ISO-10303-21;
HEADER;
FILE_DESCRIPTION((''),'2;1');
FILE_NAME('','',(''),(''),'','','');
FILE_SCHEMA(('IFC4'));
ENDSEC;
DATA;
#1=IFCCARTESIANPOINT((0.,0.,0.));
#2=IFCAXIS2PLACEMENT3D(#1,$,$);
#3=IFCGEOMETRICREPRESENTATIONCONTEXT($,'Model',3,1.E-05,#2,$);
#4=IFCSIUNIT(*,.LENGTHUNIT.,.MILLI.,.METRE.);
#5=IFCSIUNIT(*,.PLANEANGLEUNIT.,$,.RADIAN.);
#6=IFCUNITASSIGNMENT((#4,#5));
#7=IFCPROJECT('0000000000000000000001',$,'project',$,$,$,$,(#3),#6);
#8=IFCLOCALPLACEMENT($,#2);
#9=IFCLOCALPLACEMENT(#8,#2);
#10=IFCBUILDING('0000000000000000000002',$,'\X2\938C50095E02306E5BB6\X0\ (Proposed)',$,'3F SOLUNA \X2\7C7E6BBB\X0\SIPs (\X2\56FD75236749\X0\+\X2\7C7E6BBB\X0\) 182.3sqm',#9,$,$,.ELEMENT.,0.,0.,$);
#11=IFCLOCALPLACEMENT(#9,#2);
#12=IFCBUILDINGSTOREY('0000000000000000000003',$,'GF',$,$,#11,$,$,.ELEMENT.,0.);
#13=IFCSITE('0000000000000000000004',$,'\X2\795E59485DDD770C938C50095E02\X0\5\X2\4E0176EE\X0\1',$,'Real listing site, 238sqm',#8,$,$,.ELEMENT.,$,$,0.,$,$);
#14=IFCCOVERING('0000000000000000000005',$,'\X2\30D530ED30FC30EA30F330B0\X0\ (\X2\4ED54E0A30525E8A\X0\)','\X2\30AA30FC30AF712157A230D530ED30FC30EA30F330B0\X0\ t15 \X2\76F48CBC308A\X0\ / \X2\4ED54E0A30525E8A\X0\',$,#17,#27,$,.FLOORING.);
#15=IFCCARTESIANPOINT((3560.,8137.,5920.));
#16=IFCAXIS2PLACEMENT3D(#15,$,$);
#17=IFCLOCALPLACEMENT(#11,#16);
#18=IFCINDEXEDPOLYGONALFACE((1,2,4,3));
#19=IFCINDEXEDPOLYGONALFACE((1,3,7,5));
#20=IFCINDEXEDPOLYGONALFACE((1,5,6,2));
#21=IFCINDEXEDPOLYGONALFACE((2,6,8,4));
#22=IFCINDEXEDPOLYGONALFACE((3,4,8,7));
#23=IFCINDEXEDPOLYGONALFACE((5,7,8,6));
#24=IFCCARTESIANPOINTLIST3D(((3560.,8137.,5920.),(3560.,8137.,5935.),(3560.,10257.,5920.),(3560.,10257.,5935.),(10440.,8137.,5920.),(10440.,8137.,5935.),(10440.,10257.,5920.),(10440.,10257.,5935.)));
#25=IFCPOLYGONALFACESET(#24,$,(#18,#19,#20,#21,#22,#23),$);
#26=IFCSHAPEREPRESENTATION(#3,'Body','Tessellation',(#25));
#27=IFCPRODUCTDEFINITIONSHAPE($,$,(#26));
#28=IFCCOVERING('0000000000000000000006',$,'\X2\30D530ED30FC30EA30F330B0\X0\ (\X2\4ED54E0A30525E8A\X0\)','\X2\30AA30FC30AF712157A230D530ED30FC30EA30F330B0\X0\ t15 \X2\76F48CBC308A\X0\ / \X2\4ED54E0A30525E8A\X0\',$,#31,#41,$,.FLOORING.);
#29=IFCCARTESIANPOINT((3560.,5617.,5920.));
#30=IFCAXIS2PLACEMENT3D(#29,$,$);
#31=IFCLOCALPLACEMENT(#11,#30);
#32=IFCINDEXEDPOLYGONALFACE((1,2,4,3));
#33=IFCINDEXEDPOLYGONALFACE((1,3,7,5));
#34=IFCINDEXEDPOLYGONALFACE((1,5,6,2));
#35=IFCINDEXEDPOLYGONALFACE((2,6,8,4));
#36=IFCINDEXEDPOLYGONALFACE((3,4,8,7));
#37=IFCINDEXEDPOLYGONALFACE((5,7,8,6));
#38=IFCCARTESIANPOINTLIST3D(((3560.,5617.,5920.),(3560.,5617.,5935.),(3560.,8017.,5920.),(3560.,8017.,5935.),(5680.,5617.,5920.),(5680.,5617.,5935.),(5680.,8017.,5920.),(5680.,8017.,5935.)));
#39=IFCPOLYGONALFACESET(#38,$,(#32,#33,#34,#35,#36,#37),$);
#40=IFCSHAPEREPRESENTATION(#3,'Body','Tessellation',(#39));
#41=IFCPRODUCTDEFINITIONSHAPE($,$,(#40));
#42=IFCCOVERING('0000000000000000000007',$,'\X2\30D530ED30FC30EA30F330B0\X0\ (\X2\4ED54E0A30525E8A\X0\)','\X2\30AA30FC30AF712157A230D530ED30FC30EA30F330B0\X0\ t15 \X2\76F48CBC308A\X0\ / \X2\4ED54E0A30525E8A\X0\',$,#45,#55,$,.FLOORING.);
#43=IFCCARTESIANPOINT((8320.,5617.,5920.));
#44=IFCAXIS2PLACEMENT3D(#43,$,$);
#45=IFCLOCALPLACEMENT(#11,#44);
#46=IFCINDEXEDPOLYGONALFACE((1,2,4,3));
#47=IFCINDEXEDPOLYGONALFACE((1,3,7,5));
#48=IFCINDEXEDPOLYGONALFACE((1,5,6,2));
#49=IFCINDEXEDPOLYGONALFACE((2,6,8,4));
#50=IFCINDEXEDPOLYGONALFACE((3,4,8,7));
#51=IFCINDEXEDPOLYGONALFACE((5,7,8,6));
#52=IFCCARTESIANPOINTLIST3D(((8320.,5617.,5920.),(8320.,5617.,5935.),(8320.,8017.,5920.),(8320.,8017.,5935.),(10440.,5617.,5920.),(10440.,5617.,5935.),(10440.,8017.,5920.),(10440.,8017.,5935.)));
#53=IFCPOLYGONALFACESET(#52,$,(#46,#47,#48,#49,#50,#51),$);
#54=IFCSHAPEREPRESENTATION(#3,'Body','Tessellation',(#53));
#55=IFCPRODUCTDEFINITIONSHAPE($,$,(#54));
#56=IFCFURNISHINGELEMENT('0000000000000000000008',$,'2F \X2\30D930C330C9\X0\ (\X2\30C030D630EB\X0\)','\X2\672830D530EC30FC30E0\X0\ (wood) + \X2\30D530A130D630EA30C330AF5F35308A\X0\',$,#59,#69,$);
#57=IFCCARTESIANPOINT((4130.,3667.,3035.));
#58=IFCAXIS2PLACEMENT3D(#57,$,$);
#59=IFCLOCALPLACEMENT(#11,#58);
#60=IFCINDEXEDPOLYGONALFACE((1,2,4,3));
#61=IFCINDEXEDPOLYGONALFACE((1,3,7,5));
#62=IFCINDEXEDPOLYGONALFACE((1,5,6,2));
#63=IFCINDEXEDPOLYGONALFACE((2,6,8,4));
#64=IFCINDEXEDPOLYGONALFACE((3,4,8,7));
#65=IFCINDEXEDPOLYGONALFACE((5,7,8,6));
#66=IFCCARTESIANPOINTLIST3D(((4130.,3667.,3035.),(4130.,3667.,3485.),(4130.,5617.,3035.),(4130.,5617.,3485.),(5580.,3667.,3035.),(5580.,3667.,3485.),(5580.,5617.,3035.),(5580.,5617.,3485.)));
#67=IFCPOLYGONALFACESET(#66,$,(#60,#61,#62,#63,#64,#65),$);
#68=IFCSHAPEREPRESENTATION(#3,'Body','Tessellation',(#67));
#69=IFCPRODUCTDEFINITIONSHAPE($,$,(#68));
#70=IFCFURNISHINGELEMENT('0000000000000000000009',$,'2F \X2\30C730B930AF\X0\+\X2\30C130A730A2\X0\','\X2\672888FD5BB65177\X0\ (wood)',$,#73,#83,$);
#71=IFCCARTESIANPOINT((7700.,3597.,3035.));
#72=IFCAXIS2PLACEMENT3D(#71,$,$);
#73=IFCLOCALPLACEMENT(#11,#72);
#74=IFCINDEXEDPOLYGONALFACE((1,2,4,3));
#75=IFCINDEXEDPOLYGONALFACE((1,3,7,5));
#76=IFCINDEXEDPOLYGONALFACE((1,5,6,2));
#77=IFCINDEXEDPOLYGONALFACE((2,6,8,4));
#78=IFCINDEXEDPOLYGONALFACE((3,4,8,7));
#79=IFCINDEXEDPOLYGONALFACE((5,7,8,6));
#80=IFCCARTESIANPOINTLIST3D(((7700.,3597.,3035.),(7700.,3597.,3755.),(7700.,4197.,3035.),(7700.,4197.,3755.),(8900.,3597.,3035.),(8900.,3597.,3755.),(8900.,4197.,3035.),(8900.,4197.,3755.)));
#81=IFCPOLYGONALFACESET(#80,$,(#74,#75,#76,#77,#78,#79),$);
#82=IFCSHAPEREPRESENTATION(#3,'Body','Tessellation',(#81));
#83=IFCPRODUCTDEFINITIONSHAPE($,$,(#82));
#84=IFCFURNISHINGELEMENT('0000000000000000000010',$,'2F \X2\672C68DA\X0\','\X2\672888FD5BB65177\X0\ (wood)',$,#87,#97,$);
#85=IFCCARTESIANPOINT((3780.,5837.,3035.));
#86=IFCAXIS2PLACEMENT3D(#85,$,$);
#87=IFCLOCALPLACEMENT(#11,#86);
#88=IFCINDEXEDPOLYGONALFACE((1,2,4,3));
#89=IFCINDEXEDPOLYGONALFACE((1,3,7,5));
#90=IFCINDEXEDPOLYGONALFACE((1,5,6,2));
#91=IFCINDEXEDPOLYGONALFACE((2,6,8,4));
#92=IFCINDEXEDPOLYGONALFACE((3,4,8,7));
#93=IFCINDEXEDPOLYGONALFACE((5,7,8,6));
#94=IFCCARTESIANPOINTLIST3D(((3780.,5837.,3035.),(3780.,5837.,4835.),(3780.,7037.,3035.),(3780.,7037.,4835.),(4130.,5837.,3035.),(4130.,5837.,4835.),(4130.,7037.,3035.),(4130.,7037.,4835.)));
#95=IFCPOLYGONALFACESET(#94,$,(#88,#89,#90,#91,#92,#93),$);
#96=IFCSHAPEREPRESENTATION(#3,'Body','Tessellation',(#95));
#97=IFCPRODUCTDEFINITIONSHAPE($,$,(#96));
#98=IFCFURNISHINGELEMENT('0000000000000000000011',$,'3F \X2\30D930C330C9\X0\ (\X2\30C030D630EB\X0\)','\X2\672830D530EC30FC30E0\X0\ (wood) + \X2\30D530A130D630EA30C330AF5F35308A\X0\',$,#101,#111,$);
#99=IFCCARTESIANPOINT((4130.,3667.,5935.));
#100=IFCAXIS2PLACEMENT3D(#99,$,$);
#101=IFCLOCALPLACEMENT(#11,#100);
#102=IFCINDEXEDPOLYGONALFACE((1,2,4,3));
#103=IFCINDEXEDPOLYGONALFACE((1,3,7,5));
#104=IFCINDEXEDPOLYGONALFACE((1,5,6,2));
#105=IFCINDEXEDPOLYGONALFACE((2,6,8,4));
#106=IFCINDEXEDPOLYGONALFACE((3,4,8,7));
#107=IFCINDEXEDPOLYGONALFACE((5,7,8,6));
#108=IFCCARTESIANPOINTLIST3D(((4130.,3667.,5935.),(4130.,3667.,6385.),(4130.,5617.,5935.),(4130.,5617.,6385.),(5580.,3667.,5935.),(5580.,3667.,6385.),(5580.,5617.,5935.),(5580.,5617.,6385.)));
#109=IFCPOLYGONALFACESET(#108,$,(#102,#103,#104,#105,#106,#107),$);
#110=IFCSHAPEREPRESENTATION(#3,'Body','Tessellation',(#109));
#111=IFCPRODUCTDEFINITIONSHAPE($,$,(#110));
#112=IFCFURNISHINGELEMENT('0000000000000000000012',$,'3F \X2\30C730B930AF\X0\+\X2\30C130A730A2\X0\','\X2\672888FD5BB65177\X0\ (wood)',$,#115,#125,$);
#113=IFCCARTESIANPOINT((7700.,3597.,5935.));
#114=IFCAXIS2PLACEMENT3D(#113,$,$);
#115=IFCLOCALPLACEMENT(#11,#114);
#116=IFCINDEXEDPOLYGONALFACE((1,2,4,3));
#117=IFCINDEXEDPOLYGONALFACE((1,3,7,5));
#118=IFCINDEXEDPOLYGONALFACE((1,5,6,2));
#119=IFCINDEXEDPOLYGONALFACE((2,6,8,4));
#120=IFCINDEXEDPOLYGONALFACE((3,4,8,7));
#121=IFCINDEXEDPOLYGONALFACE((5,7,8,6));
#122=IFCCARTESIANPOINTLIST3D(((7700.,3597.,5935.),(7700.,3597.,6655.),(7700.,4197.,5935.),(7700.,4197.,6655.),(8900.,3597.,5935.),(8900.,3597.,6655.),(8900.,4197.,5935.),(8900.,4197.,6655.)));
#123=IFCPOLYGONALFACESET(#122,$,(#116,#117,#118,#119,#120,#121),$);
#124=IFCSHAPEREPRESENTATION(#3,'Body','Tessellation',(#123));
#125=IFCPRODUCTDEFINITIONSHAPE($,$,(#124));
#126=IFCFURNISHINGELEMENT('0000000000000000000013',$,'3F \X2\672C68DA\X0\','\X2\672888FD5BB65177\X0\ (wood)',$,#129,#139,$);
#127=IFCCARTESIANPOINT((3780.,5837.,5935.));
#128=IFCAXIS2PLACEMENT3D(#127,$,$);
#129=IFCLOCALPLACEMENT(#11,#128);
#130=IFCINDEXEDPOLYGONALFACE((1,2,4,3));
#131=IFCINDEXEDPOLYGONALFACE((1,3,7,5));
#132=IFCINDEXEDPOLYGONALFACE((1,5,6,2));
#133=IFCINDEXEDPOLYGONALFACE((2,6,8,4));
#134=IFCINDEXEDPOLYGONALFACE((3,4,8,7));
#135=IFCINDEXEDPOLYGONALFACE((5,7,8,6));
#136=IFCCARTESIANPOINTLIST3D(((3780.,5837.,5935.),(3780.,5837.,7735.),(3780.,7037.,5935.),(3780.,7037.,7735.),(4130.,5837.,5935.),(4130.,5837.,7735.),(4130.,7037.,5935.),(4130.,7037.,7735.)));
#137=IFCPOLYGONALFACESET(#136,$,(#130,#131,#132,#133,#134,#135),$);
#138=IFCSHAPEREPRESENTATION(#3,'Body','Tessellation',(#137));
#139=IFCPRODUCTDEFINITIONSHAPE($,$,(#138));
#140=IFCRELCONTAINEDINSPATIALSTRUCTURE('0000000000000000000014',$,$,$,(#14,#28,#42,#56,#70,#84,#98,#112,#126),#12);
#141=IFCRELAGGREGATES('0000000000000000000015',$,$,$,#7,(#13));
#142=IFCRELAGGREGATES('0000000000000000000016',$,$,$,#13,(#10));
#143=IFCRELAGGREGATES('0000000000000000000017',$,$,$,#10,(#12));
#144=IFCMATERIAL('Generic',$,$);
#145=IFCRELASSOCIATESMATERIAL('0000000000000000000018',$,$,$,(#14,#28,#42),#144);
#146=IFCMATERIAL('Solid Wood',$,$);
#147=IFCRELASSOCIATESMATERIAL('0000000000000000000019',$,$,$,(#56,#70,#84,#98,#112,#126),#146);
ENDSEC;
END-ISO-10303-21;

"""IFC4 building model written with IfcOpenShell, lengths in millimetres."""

from ifc_helpers import new_model, si_unit, frame, frame_2d, origin, place, context, project, spatial, rectangle, extrude, material, element, save


model = new_model("IFC4")

# Units and contexts
model_context = context("Model", 3, precision=1e-05, world=origin())
ifc_project = project(units=[si_unit("LENGTHUNIT", "METRE", prefix="MILLI"), si_unit("PLANEANGLEUNIT", "RADIAN")], contexts=[model_context])

# Site, building, storey
site_placement = place(None, origin())
site = spatial("IfcSite", under=ifc_project, at=site_placement, Name="神奈川県鎌倉市5丁目1", ObjectType="Real listing site, 238sqm", CompositionType="ELEMENT", RefElevation=0.0)
building_placement = place(site_placement, origin())
building = spatial("IfcBuilding", under=site, at=building_placement, Name="鎌倉市の家 (Proposed)", ObjectType="3F SOLUNA 籾殻SIPs (国産杉+籾殻) 182.3sqm", CompositionType="ELEMENT", ElevationOfRefHeight=0.0, ElevationOfTerrain=0.0)
storey_placement = place(building_placement, origin())
storey = spatial("IfcBuildingStorey", under=building, at=storey_placement, Name="GF", CompositionType="ELEMENT", Elevation=0.0)

# Shared definitions
ifc_material_1 = material(Name="Solid Wood")

# Shared definitions
ifc_material_2 = material(Name="Generic")

# Coverings
covering_1_placement = place(storey_placement, frame((3560.0, 8137.0, 5920.0)))
element("IfcCovering", 1, at=covering_1_placement, inside=storey, material=ifc_material_2, Name="フローリング (仕上げ床)", Description="オーク無垢フローリング t15 直貼り / 仕上げ床", PredefinedType="FLOORING", context=model_context, shape_type="SweptSolid", body=[
    extrude(rectangle(XDim=6880.0, YDim=2120.0, at=frame_2d((3440.0, 1060.0))), frame((3560.0, 8137.0, 5920.0)), (0.0, 0.0, 1.0), 15.0),
])
covering_2_placement = place(storey_placement, frame((3560.0, 5617.0, 5920.0)))
element("IfcCovering", 2, at=covering_2_placement, inside=storey, material=ifc_material_2, Name="フローリング (仕上げ床)", Description="オーク無垢フローリング t15 直貼り / 仕上げ床", PredefinedType="FLOORING", context=model_context, shape_type="SweptSolid", body=[
    extrude(rectangle(XDim=2120.0, YDim=2400.0, at=frame_2d((1060.0, 1200.0))), frame((3560.0, 5617.0, 5920.0)), (0.0, 0.0, 1.0), 15.0),
])
covering_3_placement = place(storey_placement, frame((8320.0, 5617.0, 5920.0)))
element("IfcCovering", 3, at=covering_3_placement, inside=storey, material=ifc_material_2, Name="フローリング (仕上げ床)", Description="オーク無垢フローリング t15 直貼り / 仕上げ床", PredefinedType="FLOORING", context=model_context, shape_type="SweptSolid", body=[
    extrude(rectangle(XDim=2120.0, YDim=2400.0, at=frame_2d((1060.0, 1200.0))), frame((8320.0, 5617.0, 5920.0)), (0.0, 0.0, 1.0), 15.0),
])

# Furnishing elements
furnishing_1_placement = place(storey_placement, frame((4130.0, 3667.0, 3035.0)))
element("IfcFurnishingElement", 4, at=furnishing_1_placement, inside=storey, material=ifc_material_1, Name="2F ベッド (ダブル)", Description="木フレーム (wood) + ファブリック張り", context=model_context, shape_type="SweptSolid", body=[
    extrude(rectangle(XDim=1450.0, YDim=1950.0, at=frame_2d((725.0, 975.0))), frame((4130.0, 3667.0, 3035.0)), (0.0, 0.0, 1.0), 450.0),
])
furnishing_2_placement = place(storey_placement, frame((7700.0, 3597.0, 3035.0)))
element("IfcFurnishingElement", 5, at=furnishing_2_placement, inside=storey, material=ifc_material_1, Name="2F デスク+チェア", Description="木製家具 (wood)", context=model_context, shape_type="SweptSolid", body=[
    extrude(rectangle(XDim=1200.0, YDim=600.0, at=frame_2d((600.0, 300.0))), frame((7700.0, 3597.0, 3035.0)), (0.0, 0.0, 1.0), 720.0),
])
furnishing_3_placement = place(storey_placement, frame((3780.0, 5837.0, 3035.0)))
element("IfcFurnishingElement", 6, at=furnishing_3_placement, inside=storey, material=ifc_material_1, Name="2F 本棚", Description="木製家具 (wood)", context=model_context, shape_type="SweptSolid", body=[
    extrude(rectangle(XDim=350.0, YDim=1200.0, at=frame_2d((175.0, 600.0))), frame((3780.0, 5837.0, 3035.0)), (0.0, 0.0, 1.0), 1800.0),
])
furnishing_4_placement = place(storey_placement, frame((4130.0, 3667.0, 5935.0)))
element("IfcFurnishingElement", 7, at=furnishing_4_placement, inside=storey, material=ifc_material_1, Name="3F ベッド (ダブル)", Description="木フレーム (wood) + ファブリック張り", context=model_context, shape_type="SweptSolid", body=[
    extrude(rectangle(XDim=1450.0, YDim=1950.0, at=frame_2d((725.0, 975.0))), frame((4130.0, 3667.0, 5935.0)), (0.0, 0.0, 1.0), 450.0),
])
furnishing_5_placement = place(storey_placement, frame((7700.0, 3597.0, 5935.0)))
element("IfcFurnishingElement", 8, at=furnishing_5_placement, inside=storey, material=ifc_material_1, Name="3F デスク+チェア", Description="木製家具 (wood)", context=model_context, shape_type="SweptSolid", body=[
    extrude(rectangle(XDim=1200.0, YDim=600.0, at=frame_2d((600.0, 300.0))), frame((7700.0, 3597.0, 5935.0)), (0.0, 0.0, 1.0), 720.0),
])
furnishing_6_placement = place(storey_placement, frame((3780.0, 5837.0, 5935.0)))
element("IfcFurnishingElement", 9, at=furnishing_6_placement, inside=storey, material=ifc_material_1, Name="3F 本棚", Description="木製家具 (wood)", context=model_context, shape_type="SweptSolid", body=[
    extrude(rectangle(XDim=350.0, YDim=1200.0, at=frame_2d((175.0, 600.0))), frame((3780.0, 5837.0, 5935.0)), (0.0, 0.0, 1.0), 1800.0),
])

save(model, "model.ifc")
